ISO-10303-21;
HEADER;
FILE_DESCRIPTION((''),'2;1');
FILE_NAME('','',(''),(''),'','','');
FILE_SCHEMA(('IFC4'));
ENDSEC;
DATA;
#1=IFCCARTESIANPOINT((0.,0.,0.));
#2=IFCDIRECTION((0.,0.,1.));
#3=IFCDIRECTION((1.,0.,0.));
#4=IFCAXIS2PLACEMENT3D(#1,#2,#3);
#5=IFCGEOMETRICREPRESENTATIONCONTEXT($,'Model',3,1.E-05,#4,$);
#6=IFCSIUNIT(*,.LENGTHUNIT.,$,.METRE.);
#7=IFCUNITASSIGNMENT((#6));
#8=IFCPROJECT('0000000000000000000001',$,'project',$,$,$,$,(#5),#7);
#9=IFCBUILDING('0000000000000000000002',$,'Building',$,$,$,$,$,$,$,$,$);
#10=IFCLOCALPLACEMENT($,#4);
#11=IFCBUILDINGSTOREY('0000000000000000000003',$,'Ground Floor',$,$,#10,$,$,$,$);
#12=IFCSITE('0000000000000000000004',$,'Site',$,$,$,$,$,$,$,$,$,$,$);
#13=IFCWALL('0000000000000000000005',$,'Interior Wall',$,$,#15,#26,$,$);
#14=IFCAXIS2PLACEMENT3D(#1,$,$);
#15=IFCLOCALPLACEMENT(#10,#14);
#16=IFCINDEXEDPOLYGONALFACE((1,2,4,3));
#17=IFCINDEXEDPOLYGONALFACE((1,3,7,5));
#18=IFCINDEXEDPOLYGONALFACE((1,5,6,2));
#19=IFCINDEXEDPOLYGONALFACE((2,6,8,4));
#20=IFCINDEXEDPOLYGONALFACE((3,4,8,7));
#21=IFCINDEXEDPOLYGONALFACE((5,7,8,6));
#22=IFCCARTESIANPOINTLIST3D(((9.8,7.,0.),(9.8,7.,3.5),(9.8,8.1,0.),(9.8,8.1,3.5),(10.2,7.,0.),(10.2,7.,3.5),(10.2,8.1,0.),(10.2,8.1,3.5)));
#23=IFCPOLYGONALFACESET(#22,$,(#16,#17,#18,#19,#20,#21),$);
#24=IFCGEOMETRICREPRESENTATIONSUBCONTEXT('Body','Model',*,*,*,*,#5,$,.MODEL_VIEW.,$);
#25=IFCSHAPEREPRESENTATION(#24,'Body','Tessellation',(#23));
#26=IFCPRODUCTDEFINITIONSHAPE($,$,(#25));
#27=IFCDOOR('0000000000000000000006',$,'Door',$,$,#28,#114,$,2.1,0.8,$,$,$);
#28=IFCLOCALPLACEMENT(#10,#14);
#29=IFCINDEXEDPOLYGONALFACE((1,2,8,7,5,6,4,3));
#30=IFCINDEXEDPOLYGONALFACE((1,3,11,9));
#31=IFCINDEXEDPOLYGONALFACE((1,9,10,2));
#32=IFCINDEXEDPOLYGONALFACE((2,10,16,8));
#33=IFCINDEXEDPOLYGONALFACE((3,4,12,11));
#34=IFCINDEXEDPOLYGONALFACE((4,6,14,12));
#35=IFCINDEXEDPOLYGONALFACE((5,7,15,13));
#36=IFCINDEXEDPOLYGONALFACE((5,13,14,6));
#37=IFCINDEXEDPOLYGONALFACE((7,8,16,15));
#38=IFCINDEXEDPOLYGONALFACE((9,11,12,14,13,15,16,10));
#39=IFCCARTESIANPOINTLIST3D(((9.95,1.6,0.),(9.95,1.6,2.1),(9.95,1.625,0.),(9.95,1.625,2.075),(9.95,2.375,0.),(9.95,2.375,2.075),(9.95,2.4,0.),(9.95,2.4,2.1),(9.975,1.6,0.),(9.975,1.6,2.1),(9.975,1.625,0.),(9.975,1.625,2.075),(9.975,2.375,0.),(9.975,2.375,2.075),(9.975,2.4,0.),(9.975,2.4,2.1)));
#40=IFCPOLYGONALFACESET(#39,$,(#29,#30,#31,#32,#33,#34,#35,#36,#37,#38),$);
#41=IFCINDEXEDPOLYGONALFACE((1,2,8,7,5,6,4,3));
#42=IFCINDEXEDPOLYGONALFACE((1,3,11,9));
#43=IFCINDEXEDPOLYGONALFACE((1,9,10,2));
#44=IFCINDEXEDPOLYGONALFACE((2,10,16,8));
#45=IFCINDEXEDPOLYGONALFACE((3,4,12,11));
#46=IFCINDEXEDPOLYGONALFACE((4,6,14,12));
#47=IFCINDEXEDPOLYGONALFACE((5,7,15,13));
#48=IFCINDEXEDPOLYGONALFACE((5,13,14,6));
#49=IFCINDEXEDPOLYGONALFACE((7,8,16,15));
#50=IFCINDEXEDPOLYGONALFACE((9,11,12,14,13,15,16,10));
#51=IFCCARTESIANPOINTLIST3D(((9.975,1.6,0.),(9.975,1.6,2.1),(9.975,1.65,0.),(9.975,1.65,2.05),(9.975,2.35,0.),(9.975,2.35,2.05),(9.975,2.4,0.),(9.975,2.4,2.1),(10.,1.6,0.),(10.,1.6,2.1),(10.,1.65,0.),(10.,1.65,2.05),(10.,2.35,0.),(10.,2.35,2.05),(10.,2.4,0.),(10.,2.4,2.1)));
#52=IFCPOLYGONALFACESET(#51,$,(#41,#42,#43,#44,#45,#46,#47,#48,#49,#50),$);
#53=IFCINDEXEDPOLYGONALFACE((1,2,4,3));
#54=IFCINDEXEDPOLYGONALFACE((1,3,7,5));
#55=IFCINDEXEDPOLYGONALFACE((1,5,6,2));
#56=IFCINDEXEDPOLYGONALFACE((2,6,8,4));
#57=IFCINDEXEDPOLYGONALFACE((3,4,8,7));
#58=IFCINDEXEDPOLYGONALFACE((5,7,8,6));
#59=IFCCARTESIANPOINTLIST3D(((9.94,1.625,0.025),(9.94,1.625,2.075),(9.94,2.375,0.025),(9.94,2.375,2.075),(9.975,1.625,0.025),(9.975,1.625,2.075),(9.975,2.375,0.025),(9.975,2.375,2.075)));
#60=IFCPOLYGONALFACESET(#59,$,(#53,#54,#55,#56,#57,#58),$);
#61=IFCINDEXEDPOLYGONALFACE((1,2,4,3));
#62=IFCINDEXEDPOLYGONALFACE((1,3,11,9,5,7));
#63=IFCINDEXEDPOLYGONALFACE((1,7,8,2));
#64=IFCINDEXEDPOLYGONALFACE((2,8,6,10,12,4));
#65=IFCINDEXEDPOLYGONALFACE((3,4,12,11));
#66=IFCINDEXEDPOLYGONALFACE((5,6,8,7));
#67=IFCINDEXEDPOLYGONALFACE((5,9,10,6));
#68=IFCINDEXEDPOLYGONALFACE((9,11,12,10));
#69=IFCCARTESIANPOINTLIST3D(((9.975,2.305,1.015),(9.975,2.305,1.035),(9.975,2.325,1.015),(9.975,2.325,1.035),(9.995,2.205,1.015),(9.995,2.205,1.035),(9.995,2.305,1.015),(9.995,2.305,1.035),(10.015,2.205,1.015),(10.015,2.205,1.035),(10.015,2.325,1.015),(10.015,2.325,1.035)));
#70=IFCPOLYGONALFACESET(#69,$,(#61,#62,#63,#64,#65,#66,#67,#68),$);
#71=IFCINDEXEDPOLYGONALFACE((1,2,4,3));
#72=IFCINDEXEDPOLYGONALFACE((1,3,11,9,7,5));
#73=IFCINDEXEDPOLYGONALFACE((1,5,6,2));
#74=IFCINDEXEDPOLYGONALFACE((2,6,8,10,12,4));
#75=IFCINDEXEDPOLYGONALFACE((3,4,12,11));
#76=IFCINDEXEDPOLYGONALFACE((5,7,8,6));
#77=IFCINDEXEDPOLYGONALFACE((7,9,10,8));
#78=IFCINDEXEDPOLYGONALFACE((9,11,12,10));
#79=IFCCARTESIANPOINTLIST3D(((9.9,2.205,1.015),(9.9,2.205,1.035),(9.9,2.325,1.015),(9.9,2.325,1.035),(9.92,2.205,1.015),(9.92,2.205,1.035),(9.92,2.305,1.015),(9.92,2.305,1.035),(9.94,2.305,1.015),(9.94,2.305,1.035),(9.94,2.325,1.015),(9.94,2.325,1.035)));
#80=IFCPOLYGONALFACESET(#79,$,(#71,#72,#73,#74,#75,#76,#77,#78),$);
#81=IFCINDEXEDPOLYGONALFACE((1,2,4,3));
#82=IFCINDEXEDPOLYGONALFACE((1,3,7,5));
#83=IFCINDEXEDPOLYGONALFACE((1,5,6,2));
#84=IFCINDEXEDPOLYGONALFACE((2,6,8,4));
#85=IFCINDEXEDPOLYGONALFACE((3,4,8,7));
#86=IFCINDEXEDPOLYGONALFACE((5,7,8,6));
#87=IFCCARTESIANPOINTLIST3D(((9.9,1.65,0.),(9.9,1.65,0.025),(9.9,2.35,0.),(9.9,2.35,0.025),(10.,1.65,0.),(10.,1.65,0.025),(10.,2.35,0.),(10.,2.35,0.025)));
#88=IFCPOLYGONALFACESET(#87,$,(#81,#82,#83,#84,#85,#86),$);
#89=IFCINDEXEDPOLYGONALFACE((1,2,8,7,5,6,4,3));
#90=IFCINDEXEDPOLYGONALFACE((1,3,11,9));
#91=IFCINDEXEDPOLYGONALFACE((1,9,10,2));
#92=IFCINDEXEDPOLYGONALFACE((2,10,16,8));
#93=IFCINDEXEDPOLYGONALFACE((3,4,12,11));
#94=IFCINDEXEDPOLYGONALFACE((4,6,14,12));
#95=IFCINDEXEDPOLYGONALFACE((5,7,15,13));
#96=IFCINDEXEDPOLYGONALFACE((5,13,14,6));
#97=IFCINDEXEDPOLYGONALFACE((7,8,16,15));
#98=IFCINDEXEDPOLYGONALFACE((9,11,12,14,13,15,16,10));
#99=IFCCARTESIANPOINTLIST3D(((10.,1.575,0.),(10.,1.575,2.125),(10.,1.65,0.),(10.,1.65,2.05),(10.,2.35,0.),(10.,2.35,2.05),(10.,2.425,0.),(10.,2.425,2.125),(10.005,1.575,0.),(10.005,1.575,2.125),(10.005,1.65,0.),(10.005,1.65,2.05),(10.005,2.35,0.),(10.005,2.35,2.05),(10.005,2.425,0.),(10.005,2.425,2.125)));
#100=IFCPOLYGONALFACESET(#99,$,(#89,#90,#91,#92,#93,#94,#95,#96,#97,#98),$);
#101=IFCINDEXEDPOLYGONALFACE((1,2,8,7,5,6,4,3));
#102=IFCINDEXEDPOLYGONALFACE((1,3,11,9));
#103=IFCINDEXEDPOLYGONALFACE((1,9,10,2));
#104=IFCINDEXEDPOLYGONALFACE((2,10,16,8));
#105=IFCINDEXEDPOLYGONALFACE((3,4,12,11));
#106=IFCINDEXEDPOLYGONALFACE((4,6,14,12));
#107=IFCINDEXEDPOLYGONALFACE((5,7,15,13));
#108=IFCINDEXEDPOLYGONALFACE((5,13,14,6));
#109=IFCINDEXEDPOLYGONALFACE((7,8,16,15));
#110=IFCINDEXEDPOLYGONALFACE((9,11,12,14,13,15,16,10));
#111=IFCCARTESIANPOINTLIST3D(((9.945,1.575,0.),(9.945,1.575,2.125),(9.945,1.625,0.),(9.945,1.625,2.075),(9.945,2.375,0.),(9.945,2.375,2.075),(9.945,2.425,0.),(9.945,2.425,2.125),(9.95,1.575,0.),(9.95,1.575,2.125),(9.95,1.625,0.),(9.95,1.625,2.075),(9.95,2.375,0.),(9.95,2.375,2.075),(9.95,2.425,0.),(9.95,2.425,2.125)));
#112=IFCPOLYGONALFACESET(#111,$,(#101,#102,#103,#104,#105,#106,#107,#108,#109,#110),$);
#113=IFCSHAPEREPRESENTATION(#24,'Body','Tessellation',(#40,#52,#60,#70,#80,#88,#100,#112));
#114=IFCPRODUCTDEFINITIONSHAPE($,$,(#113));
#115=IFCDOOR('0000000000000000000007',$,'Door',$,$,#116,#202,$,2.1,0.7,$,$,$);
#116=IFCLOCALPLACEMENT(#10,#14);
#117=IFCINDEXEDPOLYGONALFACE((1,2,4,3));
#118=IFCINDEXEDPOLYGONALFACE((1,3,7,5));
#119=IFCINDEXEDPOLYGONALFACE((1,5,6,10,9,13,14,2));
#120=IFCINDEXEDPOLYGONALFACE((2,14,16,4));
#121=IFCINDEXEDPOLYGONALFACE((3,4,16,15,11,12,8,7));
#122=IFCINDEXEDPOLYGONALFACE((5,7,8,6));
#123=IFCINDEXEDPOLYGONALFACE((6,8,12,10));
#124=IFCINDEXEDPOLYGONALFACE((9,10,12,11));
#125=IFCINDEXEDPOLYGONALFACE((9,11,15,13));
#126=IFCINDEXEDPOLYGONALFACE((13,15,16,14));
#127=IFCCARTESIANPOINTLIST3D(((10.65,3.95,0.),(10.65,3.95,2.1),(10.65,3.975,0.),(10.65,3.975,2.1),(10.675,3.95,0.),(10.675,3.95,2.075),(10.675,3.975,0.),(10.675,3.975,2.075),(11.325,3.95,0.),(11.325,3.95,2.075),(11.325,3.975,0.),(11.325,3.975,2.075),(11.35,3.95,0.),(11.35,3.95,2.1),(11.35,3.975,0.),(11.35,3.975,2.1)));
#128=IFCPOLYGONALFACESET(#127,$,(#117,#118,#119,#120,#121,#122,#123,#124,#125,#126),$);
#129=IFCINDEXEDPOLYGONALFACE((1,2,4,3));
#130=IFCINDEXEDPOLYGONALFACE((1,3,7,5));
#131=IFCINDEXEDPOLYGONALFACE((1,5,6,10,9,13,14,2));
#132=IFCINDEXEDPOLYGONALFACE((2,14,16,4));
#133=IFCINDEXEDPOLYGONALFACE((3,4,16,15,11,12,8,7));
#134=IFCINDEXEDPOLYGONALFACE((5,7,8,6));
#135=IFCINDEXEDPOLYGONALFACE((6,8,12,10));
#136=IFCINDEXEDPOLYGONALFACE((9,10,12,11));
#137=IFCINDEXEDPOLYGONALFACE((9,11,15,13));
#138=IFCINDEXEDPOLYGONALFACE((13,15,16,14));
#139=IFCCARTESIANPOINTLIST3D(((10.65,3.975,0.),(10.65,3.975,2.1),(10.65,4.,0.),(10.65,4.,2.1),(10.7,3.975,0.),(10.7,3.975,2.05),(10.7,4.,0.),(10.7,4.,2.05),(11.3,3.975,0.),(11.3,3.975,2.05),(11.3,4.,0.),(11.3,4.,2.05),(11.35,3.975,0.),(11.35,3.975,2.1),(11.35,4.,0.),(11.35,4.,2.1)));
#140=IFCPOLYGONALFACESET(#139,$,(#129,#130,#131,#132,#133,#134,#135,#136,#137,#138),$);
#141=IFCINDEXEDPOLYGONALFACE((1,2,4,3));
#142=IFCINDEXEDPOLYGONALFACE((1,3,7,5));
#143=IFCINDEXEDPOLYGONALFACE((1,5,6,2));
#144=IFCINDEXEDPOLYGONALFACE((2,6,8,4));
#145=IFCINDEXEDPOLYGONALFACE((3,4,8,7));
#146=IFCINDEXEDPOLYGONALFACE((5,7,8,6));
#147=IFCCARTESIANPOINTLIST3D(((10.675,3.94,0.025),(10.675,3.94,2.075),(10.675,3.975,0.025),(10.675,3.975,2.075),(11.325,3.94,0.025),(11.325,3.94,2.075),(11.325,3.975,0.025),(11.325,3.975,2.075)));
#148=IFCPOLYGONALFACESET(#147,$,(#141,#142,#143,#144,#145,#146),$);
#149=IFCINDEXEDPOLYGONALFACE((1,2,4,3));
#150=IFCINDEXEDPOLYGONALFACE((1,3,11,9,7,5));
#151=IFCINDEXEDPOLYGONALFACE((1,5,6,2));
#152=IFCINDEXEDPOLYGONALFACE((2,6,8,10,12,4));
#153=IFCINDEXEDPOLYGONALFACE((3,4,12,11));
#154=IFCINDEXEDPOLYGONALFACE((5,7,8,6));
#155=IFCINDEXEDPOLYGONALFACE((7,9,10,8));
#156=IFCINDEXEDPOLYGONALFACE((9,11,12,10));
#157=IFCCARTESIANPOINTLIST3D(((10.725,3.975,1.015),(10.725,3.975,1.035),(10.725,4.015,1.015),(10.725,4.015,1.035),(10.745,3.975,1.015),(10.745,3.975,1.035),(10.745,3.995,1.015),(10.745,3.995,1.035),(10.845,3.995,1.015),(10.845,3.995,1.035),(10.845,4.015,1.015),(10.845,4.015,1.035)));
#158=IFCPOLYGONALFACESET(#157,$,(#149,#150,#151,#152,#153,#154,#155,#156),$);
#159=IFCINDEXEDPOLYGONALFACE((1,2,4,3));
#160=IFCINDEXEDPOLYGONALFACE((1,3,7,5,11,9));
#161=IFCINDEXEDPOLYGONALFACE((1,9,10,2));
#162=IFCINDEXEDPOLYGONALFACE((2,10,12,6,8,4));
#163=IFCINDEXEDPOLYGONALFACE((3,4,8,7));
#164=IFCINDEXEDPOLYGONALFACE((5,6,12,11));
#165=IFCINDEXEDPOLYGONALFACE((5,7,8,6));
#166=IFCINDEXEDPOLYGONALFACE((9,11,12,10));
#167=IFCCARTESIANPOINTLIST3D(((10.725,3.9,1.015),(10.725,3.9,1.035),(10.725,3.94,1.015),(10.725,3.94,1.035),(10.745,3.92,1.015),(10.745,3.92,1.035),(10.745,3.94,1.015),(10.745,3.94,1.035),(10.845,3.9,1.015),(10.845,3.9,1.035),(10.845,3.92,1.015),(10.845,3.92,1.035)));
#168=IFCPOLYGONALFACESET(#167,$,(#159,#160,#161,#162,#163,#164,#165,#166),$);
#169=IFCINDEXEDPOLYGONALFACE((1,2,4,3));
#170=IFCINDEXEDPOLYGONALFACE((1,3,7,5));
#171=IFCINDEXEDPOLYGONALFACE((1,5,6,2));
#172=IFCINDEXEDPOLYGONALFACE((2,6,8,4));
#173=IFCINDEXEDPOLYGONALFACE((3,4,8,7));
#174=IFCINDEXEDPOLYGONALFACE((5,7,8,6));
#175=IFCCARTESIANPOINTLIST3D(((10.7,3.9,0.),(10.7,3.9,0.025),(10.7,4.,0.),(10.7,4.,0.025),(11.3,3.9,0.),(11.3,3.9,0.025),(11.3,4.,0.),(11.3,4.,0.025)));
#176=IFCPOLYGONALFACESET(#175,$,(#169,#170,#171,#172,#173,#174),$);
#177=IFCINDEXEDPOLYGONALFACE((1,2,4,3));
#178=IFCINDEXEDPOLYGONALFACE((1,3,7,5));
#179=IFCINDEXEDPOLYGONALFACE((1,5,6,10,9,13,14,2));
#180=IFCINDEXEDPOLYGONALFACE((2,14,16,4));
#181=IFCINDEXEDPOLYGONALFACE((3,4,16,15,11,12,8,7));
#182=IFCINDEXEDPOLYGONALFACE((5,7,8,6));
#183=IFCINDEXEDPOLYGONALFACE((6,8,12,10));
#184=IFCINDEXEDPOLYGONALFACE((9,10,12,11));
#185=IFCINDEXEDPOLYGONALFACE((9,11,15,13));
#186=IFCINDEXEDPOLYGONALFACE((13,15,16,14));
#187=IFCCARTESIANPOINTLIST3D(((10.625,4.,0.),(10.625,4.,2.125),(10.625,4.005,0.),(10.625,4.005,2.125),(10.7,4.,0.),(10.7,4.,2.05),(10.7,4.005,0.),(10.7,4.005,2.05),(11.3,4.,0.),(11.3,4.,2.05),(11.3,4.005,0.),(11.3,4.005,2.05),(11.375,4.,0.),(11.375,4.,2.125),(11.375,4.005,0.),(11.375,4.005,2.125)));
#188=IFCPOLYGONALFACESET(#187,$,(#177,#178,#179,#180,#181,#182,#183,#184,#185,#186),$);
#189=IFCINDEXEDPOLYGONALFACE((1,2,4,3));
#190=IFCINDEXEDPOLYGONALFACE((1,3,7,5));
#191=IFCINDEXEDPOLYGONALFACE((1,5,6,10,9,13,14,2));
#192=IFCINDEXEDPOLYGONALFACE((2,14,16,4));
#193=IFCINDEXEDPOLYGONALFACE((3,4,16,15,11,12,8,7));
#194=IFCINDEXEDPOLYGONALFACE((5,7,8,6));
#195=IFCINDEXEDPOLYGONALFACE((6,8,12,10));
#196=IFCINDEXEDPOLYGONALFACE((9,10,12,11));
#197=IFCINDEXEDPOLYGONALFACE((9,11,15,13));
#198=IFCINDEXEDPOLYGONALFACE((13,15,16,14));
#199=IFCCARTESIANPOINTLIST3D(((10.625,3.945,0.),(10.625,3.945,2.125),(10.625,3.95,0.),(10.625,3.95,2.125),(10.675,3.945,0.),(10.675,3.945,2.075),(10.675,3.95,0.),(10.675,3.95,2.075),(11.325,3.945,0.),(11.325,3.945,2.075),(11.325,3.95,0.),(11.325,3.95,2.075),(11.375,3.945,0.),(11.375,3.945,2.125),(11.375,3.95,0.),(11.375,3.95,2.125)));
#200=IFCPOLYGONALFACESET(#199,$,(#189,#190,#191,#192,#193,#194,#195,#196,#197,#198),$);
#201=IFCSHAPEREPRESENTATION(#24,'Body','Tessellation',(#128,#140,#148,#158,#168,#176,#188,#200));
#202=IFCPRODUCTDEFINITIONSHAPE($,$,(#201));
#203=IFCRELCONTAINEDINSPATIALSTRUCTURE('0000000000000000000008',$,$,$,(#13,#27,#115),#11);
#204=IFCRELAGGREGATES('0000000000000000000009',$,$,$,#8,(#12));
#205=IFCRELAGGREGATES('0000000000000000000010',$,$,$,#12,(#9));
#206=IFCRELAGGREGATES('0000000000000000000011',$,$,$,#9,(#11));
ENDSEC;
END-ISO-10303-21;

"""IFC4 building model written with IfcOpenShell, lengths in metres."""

from ifc_helpers import new_model, si_unit, frame, origin_with_axes, place, context, subcontext, project, spatial, line, indexed_curve, outline, extrude, element, save


model = new_model("IFC4")

# Units and contexts
model_context = context("Model", 3, precision=1e-05, world=origin_with_axes())
body_context = subcontext(model_context, "Body", "Model", "MODEL_VIEW")
ifc_project = project(units=[si_unit("LENGTHUNIT", "METRE")], contexts=[model_context])

# Site, building, storey
site = spatial("IfcSite", under=ifc_project, Name="Site")
building = spatial("IfcBuilding", under=site, Name="Building")
storey_placement = place(None, origin_with_axes())
storey = spatial("IfcBuildingStorey", under=building, at=storey_placement, Name="Ground Floor")

# Wall
wall_1_placement = place(storey_placement, frame((10.0, 7.0, 0.0), z_axis=(0.0, 0.0, 1.0), x_axis=(0.0, 1.0, 0.0)))
element("IfcWall", 1, at=wall_1_placement, inside=storey, Name="Interior Wall", context=body_context, shape_type="SweptSolid", body=[
    extrude(outline(indexed_curve([(0.0, 0.0), (0.0, 0.4), (1.1, 0.4), (1.1, 0.0), (0.0, 0.0)], self_intersect=False)), frame((0.0, -0.2, 0.0), z_axis=(0.0, 0.0, 1.0), x_axis=(1.0, 0.0, 0.0)), (0.0, 0.0, 1.0), 3.5),
])

# Doors
door_1_placement = place(storey_placement, frame((10.0, 1.6, 0.0), z_axis=(0.0, 0.0, 1.0), x_axis=(0.0, 1.0, 0.0)))
element("IfcDoor", 2, at=door_1_placement, inside=storey, Name="Door", OverallHeight=2.1, OverallWidth=0.8, context=body_context, shape_type="SweptSolid", body=[
    extrude(outline(indexed_curve([(0.0, 0.0), (0.0, 2.1), (0.8, 2.1), (0.8, 0.0), (0.775, 0.0), (0.775, 2.075), (0.025, 2.075), (0.025, 0.0)], segments=[line(1, 2, 3, 4, 5, 6, 7, 8, 1)])), frame((0.0, 0.025, 0.0), z_axis=(0.0, -1.0, 0.0), x_axis=(1.0, 0.0, 0.0)), (0.0, 0.0, -1.0), 0.025),
    extrude(outline(indexed_curve([(0.0, 0.0), (0.0, 2.1), (0.8, 2.1), (0.8, 0.0), (0.75, 0.0), (0.75, 2.05), (0.05, 2.05), (0.05, 0.0)], segments=[line(1, 2, 3, 4, 5, 6, 7, 8, 1)])), frame((0.0, 0.0, 0.0), z_axis=(0.0, -1.0, 0.0), x_axis=(1.0, 0.0, 0.0)), (0.0, 0.0, -1.0), 0.025),
    extrude(outline(indexed_curve([(0.0, 0.0), (0.75, 0.0), (0.75, 0.035), (0.0, 0.035)], segments=[line(1, 2, 3, 4, 1)])), frame((0.025, 0.025, 0.025), z_axis=(0.0, 0.0, 1.0), x_axis=(1.0, 0.0, 0.0)), (0.0, 0.0, 1.0), 2.05),
    extrude(outline(indexed_curve([(0.0, 0.0), (0.0, -0.04), (-0.12, -0.04), (-0.12, -0.02), (-0.02, -0.02), (-0.02, 0.0)], segments=[line(1, 2, 3, 4, 5, 6, 1)])), frame((0.725, 0.025, 1.015), z_axis=(0.0, 0.0, 1.0), x_axis=(1.0, 0.0, 0.0)), (0.0, 0.0, 1.0), 0.02),
    extrude(outline(indexed_curve([(0.0, 0.0), (0.0, 0.04), (-0.12, 0.04), (-0.12, 0.02), (-0.02, 0.02), (-0.02, 0.0)], segments=[line(1, 2, 3, 4, 5, 6, 1)])), frame((0.725, 0.06, 1.015), z_axis=(0.0, 0.0, 1.0), x_axis=(1.0, 0.0, 0.0)), (0.0, 0.0, 1.0), 0.02),
    extrude(outline(indexed_curve([(0.0, 0.0), (0.7, 0.0), (0.7, 0.1), (0.0, 0.1)], segments=[line(1, 2, 3, 4, 1)])), frame((0.05, 0.0, 0.0), z_axis=(0.0, 0.0, 1.0), x_axis=(1.0, 0.0, 0.0)), (0.0, 0.0, 1.0), 0.025),
    extrude(outline(indexed_curve([(0.0, 0.0), (0.0, 2.125), (0.85, 2.125), (0.85, 0.0), (0.775, 0.0), (0.775, 2.05), (0.075, 2.05), (0.075, 0.0)], segments=[line(1, 2, 3, 4, 5, 6, 7, 8, 1)])), frame((-0.025, -0.005, 0.0), z_axis=(0.0, -1.0, 0.0), x_axis=(1.0, 0.0, 0.0)), (0.0, 0.0, -1.0), 0.005),
    extrude(outline(indexed_curve([(0.0, 0.0), (0.0, 2.125), (0.85, 2.125), (0.85, 0.0), (0.8, 0.0), (0.8, 2.075), (0.05, 2.075), (0.05, 0.0)], segments=[line(1, 2, 3, 4, 5, 6, 7, 8, 1)])), frame((-0.025, 0.05, 0.0), z_axis=(0.0, -1.0, 0.0), x_axis=(1.0, 0.0, 0.0)), (0.0, 0.0, -1.0), 0.005),
])
door_2_placement = place(storey_placement, frame((11.35, 4.0, 0.0), z_axis=(0.0, 0.0, 1.0), x_axis=(-1.0, 0.0, 0.0)))
element("IfcDoor", 3, at=door_2_placement, inside=storey, Name="Door", OverallHeight=2.1, OverallWidth=0.7, context=body_context, shape_type="SweptSolid", body=[
    extrude(outline(indexed_curve([(0.0, 0.0), (0.0, 2.1), (0.7, 2.1), (0.7, 0.0), (0.675, 0.0), (0.675, 2.075), (0.025, 2.075), (0.025, 0.0)], segments=[line(1, 2, 3, 4, 5, 6, 7, 8, 1)])), frame((0.0, 0.025, 0.0), z_axis=(0.0, -1.0, 0.0), x_axis=(1.0, 0.0, 0.0)), (0.0, 0.0, -1.0), 0.025),
    extrude(outline(indexed_curve([(0.0, 0.0), (0.0, 2.1), (0.7, 2.1), (0.7, 0.0), (0.65, 0.0), (0.65, 2.05), (0.05, 2.05), (0.05, 0.0)], segments=[line(1, 2, 3, 4, 5, 6, 7, 8, 1)])), frame((0.0, 0.0, 0.0), z_axis=(0.0, -1.0, 0.0), x_axis=(1.0, 0.0, 0.0)), (0.0, 0.0, -1.0), 0.025),
    extrude(outline(indexed_curve([(0.0, 0.0), (0.65, 0.0), (0.65, 0.035), (0.0, 0.035)], segments=[line(1, 2, 3, 4, 1)])), frame((0.025, 0.025, 0.025), z_axis=(0.0, 0.0, 1.0), x_axis=(1.0, 0.0, 0.0)), (0.0, 0.0, 1.0), 2.05),
    extrude(outline(indexed_curve([(0.0, 0.0), (0.0, -0.04), (-0.12, -0.04), (-0.12, -0.02), (-0.02, -0.02), (-0.02, 0.0)], segments=[line(1, 2, 3, 4, 5, 6, 1)])), frame((0.625, 0.025, 1.015), z_axis=(0.0, 0.0, 1.0), x_axis=(1.0, 0.0, 0.0)), (0.0, 0.0, 1.0), 0.02),
    extrude(outline(indexed_curve([(0.0, 0.0), (0.0, 0.04), (-0.12, 0.04), (-0.12, 0.02), (-0.02, 0.02), (-0.02, 0.0)], segments=[line(1, 2, 3, 4, 5, 6, 1)])), frame((0.625, 0.06, 1.015), z_axis=(0.0, 0.0, 1.0), x_axis=(1.0, 0.0, 0.0)), (0.0, 0.0, 1.0), 0.02),
    extrude(outline(indexed_curve([(0.0, 0.0), (0.6, 0.0), (0.6, 0.1), (0.0, 0.1)], segments=[line(1, 2, 3, 4, 1)])), frame((0.05, 0.0, 0.0), z_axis=(0.0, 0.0, 1.0), x_axis=(1.0, 0.0, 0.0)), (0.0, 0.0, 1.0), 0.025),
    extrude(outline(indexed_curve([(0.0, 0.0), (0.0, 2.125), (0.75, 2.125), (0.75, 0.0), (0.675, 0.0), (0.675, 2.05), (0.075, 2.05), (0.075, 0.0)], segments=[line(1, 2, 3, 4, 5, 6, 7, 8, 1)])), frame((-0.025, -0.005, 0.0), z_axis=(0.0, -1.0, 0.0), x_axis=(1.0, 0.0, 0.0)), (0.0, 0.0, -1.0), 0.005),
    extrude(outline(indexed_curve([(0.0, 0.0), (0.0, 2.125), (0.75, 2.125), (0.75, 0.0), (0.7, 0.0), (0.7, 2.075), (0.05, 2.075), (0.05, 0.0)], segments=[line(1, 2, 3, 4, 5, 6, 7, 8, 1)])), frame((-0.025, 0.05, 0.0), z_axis=(0.0, -1.0, 0.0), x_axis=(1.0, 0.0, 0.0)), (0.0, 0.0, -1.0), 0.005),
])

save(model, "model.ifc")
